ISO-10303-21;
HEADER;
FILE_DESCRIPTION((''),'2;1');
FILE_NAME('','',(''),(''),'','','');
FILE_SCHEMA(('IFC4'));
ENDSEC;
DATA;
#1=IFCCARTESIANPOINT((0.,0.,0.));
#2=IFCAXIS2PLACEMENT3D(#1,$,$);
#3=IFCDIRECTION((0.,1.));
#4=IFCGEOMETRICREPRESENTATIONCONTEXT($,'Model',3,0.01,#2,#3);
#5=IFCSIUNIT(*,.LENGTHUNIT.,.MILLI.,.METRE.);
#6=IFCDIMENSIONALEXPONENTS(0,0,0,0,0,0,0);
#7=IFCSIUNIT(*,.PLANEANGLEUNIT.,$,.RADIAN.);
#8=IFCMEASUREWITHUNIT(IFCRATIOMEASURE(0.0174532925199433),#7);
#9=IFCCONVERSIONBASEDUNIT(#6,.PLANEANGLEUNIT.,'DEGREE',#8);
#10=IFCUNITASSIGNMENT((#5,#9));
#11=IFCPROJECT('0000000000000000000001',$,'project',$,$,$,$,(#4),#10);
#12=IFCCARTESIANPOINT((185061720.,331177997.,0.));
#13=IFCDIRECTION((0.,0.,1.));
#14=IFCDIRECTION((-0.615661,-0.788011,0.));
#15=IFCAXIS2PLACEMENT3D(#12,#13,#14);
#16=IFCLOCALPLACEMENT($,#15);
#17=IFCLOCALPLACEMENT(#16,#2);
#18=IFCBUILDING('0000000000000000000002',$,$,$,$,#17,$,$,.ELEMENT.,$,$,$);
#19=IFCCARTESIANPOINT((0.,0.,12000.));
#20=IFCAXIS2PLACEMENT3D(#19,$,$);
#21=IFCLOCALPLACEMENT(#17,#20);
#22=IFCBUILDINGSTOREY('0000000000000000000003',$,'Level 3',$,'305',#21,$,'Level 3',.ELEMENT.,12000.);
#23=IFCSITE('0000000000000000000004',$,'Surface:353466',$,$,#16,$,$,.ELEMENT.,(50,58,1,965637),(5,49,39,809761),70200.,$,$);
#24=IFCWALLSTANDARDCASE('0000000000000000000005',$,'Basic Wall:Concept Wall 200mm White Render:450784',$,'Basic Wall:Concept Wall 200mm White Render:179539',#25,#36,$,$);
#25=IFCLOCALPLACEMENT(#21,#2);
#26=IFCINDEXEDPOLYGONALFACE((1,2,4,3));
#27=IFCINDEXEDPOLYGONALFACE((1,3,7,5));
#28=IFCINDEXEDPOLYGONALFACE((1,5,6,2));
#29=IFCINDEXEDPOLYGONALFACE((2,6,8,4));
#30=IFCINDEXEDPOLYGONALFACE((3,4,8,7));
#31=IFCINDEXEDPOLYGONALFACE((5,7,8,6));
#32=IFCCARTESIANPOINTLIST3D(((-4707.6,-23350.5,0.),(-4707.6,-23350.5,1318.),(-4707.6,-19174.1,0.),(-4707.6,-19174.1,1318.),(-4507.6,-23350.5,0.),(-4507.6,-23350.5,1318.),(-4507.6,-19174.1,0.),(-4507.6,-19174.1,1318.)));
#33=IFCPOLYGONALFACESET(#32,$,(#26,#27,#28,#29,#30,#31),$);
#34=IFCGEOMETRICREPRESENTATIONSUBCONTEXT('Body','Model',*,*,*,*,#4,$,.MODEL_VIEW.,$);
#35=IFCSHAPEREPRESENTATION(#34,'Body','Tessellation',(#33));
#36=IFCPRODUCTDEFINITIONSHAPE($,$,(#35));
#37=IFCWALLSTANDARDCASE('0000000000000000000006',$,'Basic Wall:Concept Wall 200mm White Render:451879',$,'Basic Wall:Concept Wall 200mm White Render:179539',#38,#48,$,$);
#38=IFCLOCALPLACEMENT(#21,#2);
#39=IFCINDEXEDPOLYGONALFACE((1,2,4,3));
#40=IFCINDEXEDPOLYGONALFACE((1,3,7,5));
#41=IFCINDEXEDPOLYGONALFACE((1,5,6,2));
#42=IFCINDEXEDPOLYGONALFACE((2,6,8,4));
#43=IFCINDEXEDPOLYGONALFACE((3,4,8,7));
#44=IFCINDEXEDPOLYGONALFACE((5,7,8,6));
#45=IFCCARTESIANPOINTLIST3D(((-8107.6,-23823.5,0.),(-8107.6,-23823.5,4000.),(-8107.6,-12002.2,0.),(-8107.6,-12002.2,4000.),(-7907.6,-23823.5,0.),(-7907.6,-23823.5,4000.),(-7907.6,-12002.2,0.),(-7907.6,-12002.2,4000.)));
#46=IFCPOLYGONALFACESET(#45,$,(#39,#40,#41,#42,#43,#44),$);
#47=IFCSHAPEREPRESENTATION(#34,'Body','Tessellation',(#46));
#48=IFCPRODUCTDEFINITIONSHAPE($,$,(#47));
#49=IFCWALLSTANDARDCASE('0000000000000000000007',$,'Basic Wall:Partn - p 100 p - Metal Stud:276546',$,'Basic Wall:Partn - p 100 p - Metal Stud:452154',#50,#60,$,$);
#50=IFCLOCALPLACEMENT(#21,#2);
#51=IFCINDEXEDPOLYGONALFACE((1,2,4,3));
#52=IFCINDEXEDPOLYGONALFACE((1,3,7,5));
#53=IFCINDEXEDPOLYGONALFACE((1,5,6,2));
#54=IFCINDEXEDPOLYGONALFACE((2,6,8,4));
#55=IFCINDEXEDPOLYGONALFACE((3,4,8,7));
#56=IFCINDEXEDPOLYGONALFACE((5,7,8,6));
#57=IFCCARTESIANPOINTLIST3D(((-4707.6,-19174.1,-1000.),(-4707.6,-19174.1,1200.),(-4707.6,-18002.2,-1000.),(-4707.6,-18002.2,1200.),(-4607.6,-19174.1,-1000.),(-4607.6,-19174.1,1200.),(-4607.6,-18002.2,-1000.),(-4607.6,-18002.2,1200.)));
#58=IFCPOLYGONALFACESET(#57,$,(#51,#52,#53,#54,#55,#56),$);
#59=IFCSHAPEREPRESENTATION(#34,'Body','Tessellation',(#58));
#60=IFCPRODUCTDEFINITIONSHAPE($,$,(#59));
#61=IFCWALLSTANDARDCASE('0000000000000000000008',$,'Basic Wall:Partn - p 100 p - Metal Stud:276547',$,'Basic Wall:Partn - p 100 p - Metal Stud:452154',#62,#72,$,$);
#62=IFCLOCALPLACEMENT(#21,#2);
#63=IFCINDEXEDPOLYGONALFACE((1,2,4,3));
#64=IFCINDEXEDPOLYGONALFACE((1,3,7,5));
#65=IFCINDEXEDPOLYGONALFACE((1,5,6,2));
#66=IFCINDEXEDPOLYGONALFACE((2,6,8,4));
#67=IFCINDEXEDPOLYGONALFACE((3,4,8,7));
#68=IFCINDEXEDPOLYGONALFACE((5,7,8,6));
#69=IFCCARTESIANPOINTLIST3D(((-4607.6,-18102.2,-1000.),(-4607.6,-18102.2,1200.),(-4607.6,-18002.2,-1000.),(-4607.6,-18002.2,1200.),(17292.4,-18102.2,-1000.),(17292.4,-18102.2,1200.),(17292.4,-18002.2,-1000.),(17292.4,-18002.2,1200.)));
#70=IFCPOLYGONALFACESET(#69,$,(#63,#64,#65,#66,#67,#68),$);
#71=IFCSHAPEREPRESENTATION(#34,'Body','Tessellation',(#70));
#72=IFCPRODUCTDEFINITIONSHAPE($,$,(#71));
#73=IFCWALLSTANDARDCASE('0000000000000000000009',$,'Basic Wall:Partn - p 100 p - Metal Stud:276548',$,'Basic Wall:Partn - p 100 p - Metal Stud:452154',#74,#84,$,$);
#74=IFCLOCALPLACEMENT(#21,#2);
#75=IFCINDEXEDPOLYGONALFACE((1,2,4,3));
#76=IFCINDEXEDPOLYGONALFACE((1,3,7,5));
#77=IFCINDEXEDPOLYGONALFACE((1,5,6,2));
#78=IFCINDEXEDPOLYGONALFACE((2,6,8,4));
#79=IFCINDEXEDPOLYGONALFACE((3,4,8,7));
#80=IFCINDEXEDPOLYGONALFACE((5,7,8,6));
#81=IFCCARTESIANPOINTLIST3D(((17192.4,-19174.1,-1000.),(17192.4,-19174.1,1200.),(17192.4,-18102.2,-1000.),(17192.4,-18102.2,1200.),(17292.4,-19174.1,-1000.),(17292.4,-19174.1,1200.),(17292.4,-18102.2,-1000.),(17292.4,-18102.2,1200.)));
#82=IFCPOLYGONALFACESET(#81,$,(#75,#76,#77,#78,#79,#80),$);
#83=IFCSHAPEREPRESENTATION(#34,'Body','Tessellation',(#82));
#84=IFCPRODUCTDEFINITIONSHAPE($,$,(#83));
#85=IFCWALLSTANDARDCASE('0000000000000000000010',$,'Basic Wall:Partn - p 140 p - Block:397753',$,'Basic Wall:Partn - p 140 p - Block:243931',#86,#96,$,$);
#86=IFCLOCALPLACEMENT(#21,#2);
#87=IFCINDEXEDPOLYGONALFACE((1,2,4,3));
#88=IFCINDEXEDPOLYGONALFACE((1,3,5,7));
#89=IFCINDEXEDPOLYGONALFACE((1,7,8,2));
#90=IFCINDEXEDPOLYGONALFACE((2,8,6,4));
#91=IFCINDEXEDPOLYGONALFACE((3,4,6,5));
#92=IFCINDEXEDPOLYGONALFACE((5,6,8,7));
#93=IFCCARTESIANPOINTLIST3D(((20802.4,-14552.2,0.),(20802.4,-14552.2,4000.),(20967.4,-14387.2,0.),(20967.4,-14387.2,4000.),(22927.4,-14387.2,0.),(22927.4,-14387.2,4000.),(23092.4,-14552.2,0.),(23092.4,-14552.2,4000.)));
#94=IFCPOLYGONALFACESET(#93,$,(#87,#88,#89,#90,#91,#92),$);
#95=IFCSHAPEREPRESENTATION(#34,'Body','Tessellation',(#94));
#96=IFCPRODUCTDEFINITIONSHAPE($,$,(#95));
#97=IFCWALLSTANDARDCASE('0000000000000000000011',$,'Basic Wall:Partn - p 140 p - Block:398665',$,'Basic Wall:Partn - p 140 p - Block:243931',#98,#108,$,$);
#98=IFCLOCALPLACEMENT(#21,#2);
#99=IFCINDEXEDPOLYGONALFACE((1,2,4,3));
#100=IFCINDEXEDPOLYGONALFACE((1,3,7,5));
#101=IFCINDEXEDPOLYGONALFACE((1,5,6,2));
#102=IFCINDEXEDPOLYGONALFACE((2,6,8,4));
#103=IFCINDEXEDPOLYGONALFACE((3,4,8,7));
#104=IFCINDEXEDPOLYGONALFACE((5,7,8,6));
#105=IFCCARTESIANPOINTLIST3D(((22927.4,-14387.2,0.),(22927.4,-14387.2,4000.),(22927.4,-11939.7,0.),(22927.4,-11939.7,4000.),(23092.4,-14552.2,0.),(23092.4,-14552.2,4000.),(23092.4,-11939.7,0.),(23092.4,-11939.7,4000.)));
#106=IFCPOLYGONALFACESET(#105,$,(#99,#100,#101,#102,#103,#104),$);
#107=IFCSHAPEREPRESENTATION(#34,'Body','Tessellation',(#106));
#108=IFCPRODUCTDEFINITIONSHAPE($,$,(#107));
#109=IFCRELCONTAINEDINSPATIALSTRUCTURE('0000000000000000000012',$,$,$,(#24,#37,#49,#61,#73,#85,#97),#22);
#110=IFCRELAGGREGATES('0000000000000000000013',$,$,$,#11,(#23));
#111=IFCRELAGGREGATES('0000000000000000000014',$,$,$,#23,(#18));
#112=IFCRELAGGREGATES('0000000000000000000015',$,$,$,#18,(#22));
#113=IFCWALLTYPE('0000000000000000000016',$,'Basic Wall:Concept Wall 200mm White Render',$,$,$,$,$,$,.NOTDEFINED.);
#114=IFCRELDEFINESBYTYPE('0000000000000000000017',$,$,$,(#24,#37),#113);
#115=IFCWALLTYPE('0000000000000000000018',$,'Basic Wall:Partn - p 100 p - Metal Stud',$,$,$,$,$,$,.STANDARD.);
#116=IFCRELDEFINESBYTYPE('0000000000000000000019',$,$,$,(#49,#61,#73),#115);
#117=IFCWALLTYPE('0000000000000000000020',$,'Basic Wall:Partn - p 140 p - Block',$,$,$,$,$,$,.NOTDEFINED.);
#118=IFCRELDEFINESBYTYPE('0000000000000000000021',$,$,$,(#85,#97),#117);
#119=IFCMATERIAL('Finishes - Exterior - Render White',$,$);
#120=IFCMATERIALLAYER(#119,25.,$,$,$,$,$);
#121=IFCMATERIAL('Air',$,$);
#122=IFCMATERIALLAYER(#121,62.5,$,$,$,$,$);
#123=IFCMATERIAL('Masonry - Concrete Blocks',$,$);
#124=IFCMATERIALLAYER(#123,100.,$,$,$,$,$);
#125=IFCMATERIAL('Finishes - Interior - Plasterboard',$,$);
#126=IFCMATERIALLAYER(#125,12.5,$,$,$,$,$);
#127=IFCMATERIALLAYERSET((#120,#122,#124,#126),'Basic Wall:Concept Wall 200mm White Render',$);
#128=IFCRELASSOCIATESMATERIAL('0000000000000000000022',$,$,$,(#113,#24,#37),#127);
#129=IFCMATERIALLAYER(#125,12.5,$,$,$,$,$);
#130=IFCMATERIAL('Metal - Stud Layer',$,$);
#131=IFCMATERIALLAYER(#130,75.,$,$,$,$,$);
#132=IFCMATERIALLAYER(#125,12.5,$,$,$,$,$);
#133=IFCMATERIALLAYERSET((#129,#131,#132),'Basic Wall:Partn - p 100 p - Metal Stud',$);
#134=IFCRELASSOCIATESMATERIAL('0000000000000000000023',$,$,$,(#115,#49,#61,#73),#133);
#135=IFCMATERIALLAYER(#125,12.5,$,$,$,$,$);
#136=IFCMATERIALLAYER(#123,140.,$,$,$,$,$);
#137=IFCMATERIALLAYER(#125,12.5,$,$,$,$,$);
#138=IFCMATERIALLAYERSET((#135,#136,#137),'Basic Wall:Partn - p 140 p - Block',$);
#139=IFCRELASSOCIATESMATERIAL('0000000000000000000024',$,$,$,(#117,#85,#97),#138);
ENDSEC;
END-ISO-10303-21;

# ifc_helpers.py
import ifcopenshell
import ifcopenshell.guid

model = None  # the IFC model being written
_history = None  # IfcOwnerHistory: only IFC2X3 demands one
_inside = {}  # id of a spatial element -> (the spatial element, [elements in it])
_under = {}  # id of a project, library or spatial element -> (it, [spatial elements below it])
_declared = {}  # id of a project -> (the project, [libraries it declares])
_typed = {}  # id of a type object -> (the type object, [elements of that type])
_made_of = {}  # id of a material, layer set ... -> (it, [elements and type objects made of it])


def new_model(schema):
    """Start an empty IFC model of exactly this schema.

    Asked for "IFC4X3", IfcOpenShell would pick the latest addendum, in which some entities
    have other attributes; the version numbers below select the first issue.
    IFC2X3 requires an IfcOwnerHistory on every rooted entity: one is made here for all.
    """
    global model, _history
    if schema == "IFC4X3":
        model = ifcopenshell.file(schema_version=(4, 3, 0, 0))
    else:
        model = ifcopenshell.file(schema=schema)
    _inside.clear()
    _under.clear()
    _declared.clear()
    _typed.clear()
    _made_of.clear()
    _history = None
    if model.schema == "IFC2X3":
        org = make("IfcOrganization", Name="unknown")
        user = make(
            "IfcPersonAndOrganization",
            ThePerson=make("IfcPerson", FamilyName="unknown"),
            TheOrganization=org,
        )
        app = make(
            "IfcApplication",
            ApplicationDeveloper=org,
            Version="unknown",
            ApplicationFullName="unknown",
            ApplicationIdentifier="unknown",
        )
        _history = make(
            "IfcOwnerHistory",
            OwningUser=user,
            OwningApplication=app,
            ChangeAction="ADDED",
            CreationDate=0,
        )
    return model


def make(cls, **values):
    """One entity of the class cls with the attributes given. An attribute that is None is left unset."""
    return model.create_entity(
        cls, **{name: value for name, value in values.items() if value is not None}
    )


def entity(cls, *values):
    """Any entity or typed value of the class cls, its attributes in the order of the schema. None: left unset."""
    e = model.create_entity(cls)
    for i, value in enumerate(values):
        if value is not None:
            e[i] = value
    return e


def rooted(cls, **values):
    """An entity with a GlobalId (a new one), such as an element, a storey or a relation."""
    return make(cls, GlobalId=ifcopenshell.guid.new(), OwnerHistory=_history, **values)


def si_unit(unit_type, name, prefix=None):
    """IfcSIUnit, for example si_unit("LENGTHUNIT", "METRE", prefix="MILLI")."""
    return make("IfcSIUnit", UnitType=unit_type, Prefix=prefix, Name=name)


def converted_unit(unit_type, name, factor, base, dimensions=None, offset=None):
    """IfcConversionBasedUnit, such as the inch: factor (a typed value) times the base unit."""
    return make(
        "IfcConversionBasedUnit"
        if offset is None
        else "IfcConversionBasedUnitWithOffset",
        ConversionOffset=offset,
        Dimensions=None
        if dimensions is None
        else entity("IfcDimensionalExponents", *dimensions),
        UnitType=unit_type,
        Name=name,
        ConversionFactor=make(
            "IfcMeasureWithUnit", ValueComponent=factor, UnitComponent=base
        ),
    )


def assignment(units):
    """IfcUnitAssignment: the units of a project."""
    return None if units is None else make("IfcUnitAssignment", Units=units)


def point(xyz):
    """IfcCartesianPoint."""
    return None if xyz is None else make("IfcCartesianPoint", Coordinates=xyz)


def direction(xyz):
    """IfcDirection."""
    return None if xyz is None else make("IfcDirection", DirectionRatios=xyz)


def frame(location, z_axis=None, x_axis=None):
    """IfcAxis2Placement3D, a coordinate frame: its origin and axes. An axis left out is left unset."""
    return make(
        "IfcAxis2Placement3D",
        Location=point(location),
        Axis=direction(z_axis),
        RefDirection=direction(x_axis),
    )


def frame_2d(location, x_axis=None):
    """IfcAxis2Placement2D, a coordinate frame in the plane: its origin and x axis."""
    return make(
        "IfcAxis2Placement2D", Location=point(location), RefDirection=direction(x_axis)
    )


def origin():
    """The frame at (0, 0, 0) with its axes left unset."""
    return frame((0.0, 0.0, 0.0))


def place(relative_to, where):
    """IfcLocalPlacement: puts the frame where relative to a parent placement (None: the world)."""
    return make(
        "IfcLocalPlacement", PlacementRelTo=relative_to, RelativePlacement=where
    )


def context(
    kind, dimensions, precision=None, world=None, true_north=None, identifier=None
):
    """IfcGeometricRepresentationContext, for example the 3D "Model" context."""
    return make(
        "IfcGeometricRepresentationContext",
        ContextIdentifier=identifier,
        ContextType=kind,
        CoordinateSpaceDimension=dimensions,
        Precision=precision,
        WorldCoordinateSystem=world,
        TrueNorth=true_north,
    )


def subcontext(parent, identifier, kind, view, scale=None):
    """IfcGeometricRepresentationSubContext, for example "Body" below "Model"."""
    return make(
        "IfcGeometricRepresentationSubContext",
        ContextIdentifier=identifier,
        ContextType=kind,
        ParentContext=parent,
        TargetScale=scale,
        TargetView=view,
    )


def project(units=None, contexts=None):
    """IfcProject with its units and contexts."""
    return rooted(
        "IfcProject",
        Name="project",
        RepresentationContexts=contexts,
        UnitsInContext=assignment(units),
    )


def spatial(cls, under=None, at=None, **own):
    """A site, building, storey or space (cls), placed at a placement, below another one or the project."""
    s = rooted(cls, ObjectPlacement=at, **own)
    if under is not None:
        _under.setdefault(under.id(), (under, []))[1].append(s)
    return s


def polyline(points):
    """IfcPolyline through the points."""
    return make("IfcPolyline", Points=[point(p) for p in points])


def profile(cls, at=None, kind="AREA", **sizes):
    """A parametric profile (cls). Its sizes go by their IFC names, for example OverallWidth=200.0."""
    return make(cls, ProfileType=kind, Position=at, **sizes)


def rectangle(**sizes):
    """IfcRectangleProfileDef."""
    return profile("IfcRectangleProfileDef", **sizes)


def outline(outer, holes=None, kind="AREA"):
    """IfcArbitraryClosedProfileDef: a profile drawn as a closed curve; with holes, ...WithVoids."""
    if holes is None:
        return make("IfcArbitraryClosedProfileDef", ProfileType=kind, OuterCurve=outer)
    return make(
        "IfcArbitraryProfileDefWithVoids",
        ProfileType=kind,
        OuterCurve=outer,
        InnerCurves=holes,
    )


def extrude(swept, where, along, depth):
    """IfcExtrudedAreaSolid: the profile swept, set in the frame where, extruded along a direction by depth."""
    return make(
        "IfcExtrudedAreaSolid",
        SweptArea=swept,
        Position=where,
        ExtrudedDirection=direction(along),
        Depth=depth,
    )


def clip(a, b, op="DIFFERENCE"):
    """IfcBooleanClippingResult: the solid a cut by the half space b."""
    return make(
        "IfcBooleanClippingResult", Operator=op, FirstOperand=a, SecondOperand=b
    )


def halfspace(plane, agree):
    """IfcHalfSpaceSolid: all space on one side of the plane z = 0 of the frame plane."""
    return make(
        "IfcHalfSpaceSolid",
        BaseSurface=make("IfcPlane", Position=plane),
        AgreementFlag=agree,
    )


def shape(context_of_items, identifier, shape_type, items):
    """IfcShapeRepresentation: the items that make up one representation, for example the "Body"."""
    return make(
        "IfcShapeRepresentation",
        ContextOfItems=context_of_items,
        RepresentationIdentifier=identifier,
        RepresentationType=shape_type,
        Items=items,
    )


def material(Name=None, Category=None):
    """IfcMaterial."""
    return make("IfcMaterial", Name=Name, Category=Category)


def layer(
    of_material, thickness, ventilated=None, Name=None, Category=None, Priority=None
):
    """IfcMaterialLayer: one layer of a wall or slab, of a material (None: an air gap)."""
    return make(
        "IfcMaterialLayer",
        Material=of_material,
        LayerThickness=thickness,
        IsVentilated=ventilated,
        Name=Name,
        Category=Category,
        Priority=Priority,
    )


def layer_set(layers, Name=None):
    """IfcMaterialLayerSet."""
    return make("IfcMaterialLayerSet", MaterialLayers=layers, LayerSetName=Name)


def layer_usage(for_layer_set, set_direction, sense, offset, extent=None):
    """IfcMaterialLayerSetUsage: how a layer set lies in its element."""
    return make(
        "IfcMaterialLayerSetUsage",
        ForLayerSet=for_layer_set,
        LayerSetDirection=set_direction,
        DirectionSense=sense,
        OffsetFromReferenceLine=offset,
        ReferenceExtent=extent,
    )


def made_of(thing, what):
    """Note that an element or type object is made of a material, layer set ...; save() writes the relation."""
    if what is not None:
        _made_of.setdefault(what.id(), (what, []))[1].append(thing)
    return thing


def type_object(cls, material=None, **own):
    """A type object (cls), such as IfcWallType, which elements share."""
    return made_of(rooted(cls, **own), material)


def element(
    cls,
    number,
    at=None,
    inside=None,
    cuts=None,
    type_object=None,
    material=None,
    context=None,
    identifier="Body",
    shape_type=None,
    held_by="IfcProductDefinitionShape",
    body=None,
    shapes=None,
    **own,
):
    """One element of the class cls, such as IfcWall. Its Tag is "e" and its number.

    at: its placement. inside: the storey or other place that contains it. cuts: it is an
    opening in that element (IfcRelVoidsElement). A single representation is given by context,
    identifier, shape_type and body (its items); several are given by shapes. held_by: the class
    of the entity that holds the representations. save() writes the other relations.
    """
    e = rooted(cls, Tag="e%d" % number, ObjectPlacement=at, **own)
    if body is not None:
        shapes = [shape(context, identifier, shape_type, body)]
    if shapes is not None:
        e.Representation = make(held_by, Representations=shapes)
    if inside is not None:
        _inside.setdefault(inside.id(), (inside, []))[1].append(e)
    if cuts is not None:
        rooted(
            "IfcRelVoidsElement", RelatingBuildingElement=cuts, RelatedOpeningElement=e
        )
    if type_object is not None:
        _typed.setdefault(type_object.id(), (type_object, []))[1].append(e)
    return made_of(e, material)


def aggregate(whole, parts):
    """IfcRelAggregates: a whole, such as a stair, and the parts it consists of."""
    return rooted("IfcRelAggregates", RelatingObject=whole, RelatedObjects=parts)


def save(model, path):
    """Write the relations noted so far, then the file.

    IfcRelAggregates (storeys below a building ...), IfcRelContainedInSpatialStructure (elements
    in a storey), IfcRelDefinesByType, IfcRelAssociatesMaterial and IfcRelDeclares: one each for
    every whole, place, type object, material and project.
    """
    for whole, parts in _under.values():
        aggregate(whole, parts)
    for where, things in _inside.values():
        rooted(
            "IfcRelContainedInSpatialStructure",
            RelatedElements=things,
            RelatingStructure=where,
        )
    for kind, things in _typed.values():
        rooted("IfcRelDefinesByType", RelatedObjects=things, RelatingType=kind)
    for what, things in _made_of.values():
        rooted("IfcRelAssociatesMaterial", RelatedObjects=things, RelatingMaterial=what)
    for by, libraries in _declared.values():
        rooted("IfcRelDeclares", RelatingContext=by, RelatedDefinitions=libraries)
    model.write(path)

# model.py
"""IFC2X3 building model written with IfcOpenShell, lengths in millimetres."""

from ifc_helpers import new_model, entity, si_unit, converted_unit, direction, frame, frame_2d, origin, place, context, subcontext, project, spatial, polyline, rectangle, outline, extrude, clip, halfspace, material, layer, layer_set, layer_usage, type_object, element, save


model = new_model("IFC2X3")

# Units and contexts
model_context = context("Model", 3, precision=0.01, world=origin(), true_north=direction((0.0, 1.0)))
body_context = subcontext(model_context, "Body", "Model", "MODEL_VIEW")
ifc_project = project(units=[si_unit("LENGTHUNIT", "METRE", prefix="MILLI"), converted_unit("PLANEANGLEUNIT", "DEGREE", entity("IfcRatioMeasure", 0.0174532925199433), si_unit("PLANEANGLEUNIT", "RADIAN"), dimensions=[0, 0, 0, 0, 0, 0, 0])], contexts=[model_context])

# Site, building, storey
site_placement = place(None, frame((185061720.0, 331177997.0, 0.0), z_axis=(0.0, 0.0, 1.0), x_axis=(-0.615661, -0.788011, 0.0)))
site = spatial("IfcSite", under=ifc_project, at=site_placement, Name="Surface:353466", CompositionType="ELEMENT", RefLatitude=(50, 58, 1, 965637), RefLongitude=(5, 49, 39, 809761), RefElevation=70200.0)
building_placement = place(site_placement, origin())
building = spatial("IfcBuilding", under=site, at=building_placement, CompositionType="ELEMENT")
storey_placement = place(building_placement, frame((0.0, 0.0, 12000.0)))
storey = spatial("IfcBuildingStorey", under=building, at=storey_placement, Name="Level 3", ObjectType="305", LongName="Level 3", CompositionType="ELEMENT", Elevation=12000.0)

# Walls
ifc_material_1 = material(Name="Masonry - Concrete Blocks")
ifc_material_2 = material(Name="Finishes - Interior - Plasterboard")
ifc_material_3 = material(Name="Finishes - Exterior - Render White")
ifc_layer_1 = layer(ifc_material_3, 25.0)
ifc_material_4 = material(Name="Air")
ifc_layer_2 = layer(ifc_material_4, 62.5)
ifc_layer_3 = layer(ifc_material_1, 100.0)
ifc_layer_4 = layer(ifc_material_2, 12.5)
ifc_layer_set_1 = layer_set([ifc_layer_1, ifc_layer_2, ifc_layer_3, ifc_layer_4], Name="Basic Wall:Concept Wall 200mm White Render")
wall_type_1 = type_object("IfcWallType", Name="Basic Wall:Concept Wall 200mm White Render", PredefinedType="NOTDEFINED", material=ifc_layer_set_1)
ifc_layer_usage_1 = layer_usage(ifc_layer_set_1, "AXIS2", "POSITIVE", -100.0)
wall_1_placement = place(storey_placement, frame((-4607.6, -23350.5, 0.0), z_axis=(0.0, 0.0, 1.0), x_axis=(0.0, 1.0, 0.0)))
element("IfcWallStandardCase", 1, at=wall_1_placement, inside=storey, type_object=wall_type_1, material=ifc_layer_usage_1, Name="Basic Wall:Concept Wall 200mm White Render:450784", ObjectType="Basic Wall:Concept Wall 200mm White Render:179539", context=body_context, shape_type="Clipping", body=[
    clip(extrude(rectangle(XDim=4176.4, YDim=200.0, at=frame_2d((2088.2, 0.0), x_axis=(-1.0, 0.0))), origin(), (0.0, 0.0, 1.0), 1318.0), halfspace(frame((0.0, 0.0, -8000.0)), True)),
])
ifc_layer_usage_2 = layer_usage(ifc_layer_set_1, "AXIS2", "POSITIVE", -100.0)
wall_2_placement = place(storey_placement, frame((-8007.6, -12002.2, 0.0), z_axis=(0.0, 0.0, 1.0), x_axis=(0.0, -1.0, 0.0)))
element("IfcWallStandardCase", 2, at=wall_2_placement, inside=storey, type_object=wall_type_1, material=ifc_layer_usage_2, Name="Basic Wall:Concept Wall 200mm White Render:451879", ObjectType="Basic Wall:Concept Wall 200mm White Render:179539", context=body_context, shape_type="Clipping", body=[
    clip(clip(extrude(rectangle(XDim=11821.2, YDim=200.0, at=frame_2d((5910.6, 0.0), x_axis=(-1.0, 0.0))), origin(), (0.0, 0.0, 1.0), 4000.0), halfspace(frame((0.0, -100.0, 4000.0), z_axis=(0.0, 0.0, 1.0), x_axis=(0.0, 1.0, 0.0)), False)), halfspace(frame((0.0, 0.0, -8000.0)), True)),
])
ifc_layer_5 = layer(ifc_material_2, 12.5)
ifc_material_5 = material(Name="Metal - Stud Layer")
ifc_layer_6 = layer(ifc_material_5, 75.0)
ifc_layer_7 = layer(ifc_material_2, 12.5)
ifc_layer_set_2 = layer_set([ifc_layer_5, ifc_layer_6, ifc_layer_7], Name="Basic Wall:Partn - p 100 p - Metal Stud")
ifc_layer_usage_3 = layer_usage(ifc_layer_set_2, "AXIS2", "POSITIVE", -50.0)
wall_type_2 = type_object("IfcWallType", Name="Basic Wall:Partn - p 100 p - Metal Stud", PredefinedType="STANDARD", material=ifc_layer_set_2)
wall_3_placement = place(storey_placement, frame((-4657.6, -19174.1, -1000.0), z_axis=(0.0, 0.0, 1.0), x_axis=(0.0, 1.0, 0.0)))
element("IfcWallStandardCase", 3, at=wall_3_placement, inside=storey, type_object=wall_type_2, material=ifc_layer_usage_3, Name="Basic Wall:Partn - p 100 p - Metal Stud:276546", ObjectType="Basic Wall:Partn - p 100 p - Metal Stud:452154", context=body_context, shape_type="SweptSolid", body=[
    extrude(rectangle(XDim=1171.9, YDim=100.0, at=frame_2d((586.0, 0.0), x_axis=(-1.0, 0.0))), origin(), (0.0, 0.0, 1.0), 2200.0),
])
ifc_layer_usage_4 = layer_usage(ifc_layer_set_2, "AXIS2", "POSITIVE", -50.0)
wall_4_placement = place(storey_placement, frame((-4607.6, -18052.2, -1000.0)))
element("IfcWallStandardCase", 4, at=wall_4_placement, inside=storey, type_object=wall_type_2, material=ifc_layer_usage_4, Name="Basic Wall:Partn - p 100 p - Metal Stud:276547", ObjectType="Basic Wall:Partn - p 100 p - Metal Stud:452154", context=body_context, shape_type="SweptSolid", body=[
    extrude(rectangle(XDim=21900.0, YDim=100.0, at=frame_2d((10950.0, 0.0), x_axis=(-1.0, 0.0))), origin(), (0.0, 0.0, 1.0), 2200.0),
])
ifc_layer_usage_5 = layer_usage(ifc_layer_set_2, "AXIS2", "POSITIVE", -50.0)
wall_5_placement = place(storey_placement, frame((17242.4, -18102.2, -1000.0), z_axis=(0.0, 0.0, 1.0), x_axis=(0.0, -1.0, 0.0)))
element("IfcWallStandardCase", 5, at=wall_5_placement, inside=storey, type_object=wall_type_2, material=ifc_layer_usage_5, Name="Basic Wall:Partn - p 100 p - Metal Stud:276548", ObjectType="Basic Wall:Partn - p 100 p - Metal Stud:452154", context=body_context, shape_type="SweptSolid", body=[
    extrude(rectangle(XDim=1071.9, YDim=100.0, at=frame_2d((536.0, 0.0), x_axis=(-1.0, 0.0))), origin(), (0.0, 0.0, 1.0), 2200.0),
])

# Walls
ifc_layer_8 = layer(ifc_material_2, 12.5)
ifc_layer_9 = layer(ifc_material_1, 140.0)
ifc_layer_10 = layer(ifc_material_2, 12.5)
ifc_layer_set_3 = layer_set([ifc_layer_8, ifc_layer_9, ifc_layer_10], Name="Basic Wall:Partn - p 140 p - Block")
ifc_layer_usage_6 = layer_usage(ifc_layer_set_3, "AXIS2", "NEGATIVE", 82.5)
wall_type_3 = type_object("IfcWallType", Name="Basic Wall:Partn - p 140 p - Block", PredefinedType="NOTDEFINED", material=ifc_layer_set_3)
wall_6_placement = place(storey_placement, frame((23092.4, -14469.7, 0.0), z_axis=(0.0, 0.0, 1.0), x_axis=(-1.0, 0.0, 0.0)))
element("IfcWallStandardCase", 6, at=wall_6_placement, inside=storey, type_object=wall_type_3, material=ifc_layer_usage_6, Name="Basic Wall:Partn - p 140 p - Block:397753", ObjectType="Basic Wall:Partn - p 140 p - Block:243931", context=body_context, shape_type="Clipping", body=[
    clip(extrude(outline(polyline([(2125.0, -82.5), (2290.0, 82.5), (0.0, 82.5), (165.0, -82.5), (2125.0, -82.5)])), origin(), (0.0, 0.0, 1.0), 4000.0), halfspace(frame((0.0, 0.0, -12000.0)), True)),
])
ifc_layer_usage_7 = layer_usage(ifc_layer_set_3, "AXIS2", "NEGATIVE", 82.5)
wall_7_placement = place(storey_placement, frame((23009.9, -14552.2, 0.0), z_axis=(0.0, 0.0, 1.0), x_axis=(0.0, 1.0, 0.0)))
element("IfcWallStandardCase", 7, at=wall_7_placement, inside=storey, type_object=wall_type_3, material=ifc_layer_usage_7, Name="Basic Wall:Partn - p 140 p - Block:398665", ObjectType="Basic Wall:Partn - p 140 p - Block:243931", context=body_context, shape_type="Clipping", body=[
    clip(extrude(outline(polyline([(2612.5, -82.5), (2612.5, 82.5), (165.0, 82.5), (0.0, -82.5), (2612.5, -82.5)])), origin(), (0.0, 0.0, 1.0), 4000.0), halfspace(frame((0.0, 0.0, -12000.0)), True)),
])

save(model, "model.ifc")
